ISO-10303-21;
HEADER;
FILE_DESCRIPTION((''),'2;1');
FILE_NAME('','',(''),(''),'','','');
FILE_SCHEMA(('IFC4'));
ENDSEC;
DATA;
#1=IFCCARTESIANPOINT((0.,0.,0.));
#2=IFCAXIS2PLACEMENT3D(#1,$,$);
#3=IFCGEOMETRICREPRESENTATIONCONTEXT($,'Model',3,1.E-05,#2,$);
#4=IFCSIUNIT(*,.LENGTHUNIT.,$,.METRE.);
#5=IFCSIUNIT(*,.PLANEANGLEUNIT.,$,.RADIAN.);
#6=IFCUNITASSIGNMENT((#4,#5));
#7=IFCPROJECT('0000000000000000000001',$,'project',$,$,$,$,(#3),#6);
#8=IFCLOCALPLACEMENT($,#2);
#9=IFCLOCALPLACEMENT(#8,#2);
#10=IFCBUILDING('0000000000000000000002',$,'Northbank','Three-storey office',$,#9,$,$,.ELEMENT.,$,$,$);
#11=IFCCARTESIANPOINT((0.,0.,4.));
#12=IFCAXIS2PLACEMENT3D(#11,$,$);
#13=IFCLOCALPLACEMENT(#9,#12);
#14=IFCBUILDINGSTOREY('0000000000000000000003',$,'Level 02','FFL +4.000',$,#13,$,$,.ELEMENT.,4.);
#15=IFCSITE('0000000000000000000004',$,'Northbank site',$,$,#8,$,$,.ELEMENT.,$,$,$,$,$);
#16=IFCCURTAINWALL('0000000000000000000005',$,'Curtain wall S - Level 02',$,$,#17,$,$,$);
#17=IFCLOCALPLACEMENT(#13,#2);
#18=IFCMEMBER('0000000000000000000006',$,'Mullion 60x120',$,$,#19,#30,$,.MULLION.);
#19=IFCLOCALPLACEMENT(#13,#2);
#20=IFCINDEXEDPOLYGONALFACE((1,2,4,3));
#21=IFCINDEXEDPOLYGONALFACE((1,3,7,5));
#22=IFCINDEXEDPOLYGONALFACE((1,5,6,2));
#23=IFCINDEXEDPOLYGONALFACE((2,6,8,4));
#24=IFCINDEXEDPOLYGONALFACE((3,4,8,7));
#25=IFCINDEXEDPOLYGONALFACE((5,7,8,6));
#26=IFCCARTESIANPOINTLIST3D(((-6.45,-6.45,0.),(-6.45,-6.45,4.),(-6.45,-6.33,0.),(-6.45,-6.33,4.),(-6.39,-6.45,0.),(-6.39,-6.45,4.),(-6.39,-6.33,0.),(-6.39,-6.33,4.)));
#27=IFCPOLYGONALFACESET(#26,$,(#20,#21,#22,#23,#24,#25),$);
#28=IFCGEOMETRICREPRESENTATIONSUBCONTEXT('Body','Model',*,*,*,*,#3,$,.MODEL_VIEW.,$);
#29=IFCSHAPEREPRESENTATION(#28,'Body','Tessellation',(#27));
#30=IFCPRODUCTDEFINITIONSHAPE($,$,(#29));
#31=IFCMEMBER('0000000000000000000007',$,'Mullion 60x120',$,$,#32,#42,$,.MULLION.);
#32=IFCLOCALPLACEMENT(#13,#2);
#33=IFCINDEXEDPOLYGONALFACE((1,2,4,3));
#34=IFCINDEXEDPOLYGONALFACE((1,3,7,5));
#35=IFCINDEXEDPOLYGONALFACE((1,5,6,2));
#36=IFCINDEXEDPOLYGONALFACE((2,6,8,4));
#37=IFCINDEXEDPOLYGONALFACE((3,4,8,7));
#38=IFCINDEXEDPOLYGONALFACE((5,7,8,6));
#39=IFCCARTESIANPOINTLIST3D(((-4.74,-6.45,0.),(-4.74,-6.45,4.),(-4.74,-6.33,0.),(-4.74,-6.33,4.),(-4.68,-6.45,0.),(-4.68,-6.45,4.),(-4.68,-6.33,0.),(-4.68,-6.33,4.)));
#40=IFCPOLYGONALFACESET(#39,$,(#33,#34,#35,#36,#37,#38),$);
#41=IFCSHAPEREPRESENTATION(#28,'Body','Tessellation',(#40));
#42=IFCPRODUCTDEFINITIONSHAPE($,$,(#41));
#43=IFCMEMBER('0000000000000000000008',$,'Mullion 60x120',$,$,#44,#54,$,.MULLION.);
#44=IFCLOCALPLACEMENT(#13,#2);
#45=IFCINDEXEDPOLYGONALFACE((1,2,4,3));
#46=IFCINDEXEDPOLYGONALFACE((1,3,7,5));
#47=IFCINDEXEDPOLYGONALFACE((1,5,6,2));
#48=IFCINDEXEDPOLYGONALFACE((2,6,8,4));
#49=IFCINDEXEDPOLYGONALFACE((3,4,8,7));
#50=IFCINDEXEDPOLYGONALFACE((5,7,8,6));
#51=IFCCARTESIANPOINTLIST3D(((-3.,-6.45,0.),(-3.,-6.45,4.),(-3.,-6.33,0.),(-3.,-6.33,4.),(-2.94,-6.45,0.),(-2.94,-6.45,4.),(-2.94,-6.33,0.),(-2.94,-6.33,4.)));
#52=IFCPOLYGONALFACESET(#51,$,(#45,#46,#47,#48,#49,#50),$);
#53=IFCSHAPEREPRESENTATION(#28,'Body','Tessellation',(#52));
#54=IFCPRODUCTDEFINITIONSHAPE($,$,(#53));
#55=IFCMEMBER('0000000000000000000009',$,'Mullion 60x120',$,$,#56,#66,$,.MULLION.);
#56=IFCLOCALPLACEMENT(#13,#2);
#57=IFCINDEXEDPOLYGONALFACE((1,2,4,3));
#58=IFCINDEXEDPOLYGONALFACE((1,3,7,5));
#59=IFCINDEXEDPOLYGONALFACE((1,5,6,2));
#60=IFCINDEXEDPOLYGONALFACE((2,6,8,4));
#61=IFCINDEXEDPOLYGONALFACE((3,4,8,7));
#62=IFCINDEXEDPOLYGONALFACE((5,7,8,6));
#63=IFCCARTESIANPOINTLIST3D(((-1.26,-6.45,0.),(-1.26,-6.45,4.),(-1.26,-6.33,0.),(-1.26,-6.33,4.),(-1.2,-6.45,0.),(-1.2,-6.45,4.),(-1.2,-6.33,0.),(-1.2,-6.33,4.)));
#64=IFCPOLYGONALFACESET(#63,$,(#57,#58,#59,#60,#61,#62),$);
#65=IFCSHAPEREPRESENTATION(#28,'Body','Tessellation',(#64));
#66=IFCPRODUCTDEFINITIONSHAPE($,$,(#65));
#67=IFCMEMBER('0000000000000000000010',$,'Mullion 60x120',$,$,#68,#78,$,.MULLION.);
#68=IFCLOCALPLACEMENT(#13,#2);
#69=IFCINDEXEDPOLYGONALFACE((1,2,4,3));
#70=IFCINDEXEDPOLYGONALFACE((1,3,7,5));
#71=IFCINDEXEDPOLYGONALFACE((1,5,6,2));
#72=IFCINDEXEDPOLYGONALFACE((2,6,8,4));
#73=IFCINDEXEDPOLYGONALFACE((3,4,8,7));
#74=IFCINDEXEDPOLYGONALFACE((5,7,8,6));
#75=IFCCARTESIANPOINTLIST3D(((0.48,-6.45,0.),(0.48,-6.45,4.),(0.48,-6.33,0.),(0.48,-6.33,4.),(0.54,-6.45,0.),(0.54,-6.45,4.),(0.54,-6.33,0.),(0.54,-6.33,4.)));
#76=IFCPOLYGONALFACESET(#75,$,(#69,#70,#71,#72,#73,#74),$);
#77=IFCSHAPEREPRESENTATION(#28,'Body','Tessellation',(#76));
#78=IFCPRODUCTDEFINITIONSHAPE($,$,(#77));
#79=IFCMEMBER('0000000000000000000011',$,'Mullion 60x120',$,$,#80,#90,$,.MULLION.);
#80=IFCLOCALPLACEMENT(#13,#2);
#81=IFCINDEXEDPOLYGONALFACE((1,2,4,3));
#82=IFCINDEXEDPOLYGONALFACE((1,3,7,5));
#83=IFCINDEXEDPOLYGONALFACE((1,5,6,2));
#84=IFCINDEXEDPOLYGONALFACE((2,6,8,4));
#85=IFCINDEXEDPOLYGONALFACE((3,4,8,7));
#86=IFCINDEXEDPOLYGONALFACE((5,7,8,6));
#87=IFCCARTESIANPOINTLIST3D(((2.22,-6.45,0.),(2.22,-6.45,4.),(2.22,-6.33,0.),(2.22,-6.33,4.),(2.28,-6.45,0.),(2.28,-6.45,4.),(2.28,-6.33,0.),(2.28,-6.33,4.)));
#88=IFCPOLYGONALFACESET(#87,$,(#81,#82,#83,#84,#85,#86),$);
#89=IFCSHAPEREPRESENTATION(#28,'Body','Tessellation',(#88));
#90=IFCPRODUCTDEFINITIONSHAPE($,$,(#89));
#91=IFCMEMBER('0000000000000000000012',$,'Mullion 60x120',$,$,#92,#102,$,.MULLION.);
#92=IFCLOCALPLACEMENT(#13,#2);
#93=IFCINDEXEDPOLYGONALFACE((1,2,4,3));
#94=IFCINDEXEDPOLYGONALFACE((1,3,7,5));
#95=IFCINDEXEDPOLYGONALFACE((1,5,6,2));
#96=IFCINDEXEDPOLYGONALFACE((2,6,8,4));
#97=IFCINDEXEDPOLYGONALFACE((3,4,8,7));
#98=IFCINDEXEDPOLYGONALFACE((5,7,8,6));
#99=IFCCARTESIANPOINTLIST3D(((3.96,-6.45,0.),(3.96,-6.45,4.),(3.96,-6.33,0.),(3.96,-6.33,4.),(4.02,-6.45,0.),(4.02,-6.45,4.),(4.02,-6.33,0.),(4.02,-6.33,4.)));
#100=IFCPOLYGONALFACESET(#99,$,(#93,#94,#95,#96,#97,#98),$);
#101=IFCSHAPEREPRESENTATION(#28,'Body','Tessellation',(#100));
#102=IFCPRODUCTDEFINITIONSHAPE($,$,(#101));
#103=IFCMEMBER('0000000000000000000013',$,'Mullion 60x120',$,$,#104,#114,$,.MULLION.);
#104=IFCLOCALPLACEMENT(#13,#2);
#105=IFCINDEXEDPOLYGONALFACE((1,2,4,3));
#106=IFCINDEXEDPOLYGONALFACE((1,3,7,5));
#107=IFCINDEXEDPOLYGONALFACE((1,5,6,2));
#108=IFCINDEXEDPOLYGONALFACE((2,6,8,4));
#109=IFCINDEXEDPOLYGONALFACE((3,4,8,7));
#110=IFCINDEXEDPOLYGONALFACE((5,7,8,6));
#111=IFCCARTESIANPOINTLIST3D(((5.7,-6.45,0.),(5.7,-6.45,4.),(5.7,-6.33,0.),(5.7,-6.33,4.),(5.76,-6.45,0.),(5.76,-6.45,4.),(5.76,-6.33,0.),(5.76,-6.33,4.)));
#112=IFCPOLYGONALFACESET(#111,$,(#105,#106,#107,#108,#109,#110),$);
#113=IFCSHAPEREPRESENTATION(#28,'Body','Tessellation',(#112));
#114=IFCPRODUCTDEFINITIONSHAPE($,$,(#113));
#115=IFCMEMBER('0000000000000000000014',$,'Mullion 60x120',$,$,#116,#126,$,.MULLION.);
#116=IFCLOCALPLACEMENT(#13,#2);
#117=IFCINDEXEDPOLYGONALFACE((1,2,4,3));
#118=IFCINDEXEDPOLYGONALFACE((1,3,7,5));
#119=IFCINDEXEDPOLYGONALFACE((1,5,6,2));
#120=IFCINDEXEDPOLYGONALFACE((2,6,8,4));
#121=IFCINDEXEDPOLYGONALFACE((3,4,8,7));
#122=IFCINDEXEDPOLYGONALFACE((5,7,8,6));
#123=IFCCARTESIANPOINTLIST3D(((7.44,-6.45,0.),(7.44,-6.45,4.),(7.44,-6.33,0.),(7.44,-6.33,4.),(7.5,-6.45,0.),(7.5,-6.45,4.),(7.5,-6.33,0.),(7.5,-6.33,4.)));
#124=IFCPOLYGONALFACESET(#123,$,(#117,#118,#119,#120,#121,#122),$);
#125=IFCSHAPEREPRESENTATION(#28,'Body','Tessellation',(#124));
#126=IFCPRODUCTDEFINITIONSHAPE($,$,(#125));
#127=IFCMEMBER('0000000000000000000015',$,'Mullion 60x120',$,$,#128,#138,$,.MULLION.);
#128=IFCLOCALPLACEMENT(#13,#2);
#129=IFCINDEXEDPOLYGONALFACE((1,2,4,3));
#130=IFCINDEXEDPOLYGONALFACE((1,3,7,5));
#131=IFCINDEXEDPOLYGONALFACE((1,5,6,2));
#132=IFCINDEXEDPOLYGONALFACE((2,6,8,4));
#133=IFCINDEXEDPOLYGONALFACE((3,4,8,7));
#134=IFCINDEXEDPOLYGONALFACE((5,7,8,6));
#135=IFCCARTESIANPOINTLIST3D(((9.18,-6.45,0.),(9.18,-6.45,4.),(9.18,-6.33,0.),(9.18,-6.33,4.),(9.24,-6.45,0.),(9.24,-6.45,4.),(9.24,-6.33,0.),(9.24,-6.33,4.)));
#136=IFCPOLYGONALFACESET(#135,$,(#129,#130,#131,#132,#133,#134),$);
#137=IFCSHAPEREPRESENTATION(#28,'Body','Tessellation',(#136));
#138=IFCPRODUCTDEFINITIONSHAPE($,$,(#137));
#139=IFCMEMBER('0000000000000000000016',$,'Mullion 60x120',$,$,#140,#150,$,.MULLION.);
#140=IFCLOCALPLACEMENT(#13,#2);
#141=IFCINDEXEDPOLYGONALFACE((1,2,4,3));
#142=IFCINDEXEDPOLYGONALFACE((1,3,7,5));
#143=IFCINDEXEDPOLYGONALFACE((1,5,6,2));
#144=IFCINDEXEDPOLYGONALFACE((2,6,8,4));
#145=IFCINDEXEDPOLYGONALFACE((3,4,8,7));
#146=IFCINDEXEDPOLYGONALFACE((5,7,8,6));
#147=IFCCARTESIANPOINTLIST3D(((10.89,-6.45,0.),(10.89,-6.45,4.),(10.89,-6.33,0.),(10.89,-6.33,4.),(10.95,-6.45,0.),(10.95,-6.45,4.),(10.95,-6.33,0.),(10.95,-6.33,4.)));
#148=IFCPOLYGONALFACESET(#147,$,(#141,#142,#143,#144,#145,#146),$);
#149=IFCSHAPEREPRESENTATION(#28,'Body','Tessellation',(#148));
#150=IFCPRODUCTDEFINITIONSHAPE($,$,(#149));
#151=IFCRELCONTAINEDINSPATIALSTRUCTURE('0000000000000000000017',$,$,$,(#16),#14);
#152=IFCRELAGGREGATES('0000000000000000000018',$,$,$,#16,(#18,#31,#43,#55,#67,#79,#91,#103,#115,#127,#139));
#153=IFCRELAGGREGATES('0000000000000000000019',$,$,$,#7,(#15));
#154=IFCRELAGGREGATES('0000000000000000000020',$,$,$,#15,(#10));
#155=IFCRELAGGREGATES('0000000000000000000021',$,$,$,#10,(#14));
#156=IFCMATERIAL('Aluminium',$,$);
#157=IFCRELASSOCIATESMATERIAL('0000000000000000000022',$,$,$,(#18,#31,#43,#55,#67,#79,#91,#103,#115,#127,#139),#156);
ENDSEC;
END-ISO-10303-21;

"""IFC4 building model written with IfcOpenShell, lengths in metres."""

from ifc_helpers import new_model, si_unit, frame, origin, place, context, subcontext, project, spatial, rectangle, extrude, material, element, aggregate, save


model = new_model("IFC4")

# Units and contexts
model_context = context("Model", 3, precision=1e-05, world=origin())
body_context = subcontext(model_context, "Body", "Model", "MODEL_VIEW")
ifc_project = project(units=[si_unit("LENGTHUNIT", "METRE"), si_unit("PLANEANGLEUNIT", "RADIAN")], contexts=[model_context])

# Site, building, storey
site_placement = place(None, origin())
site = spatial("IfcSite", under=ifc_project, at=site_placement, Name="Northbank site", CompositionType="ELEMENT")
building_placement = place(site_placement, origin())
building = spatial("IfcBuilding", under=site, at=building_placement, Name="Northbank", Description="Three-storey office", CompositionType="ELEMENT")
storey_placement = place(building_placement, frame((0.0, 0.0, 4.0)))
storey = spatial("IfcBuildingStorey", under=building, at=storey_placement, Name="Level 02", Description="FFL +4.000", CompositionType="ELEMENT", Elevation=4.0)

# Curtain wall, members
curtain_wall_placement = place(storey_placement, frame((0.0, 0.0, -4.0)))
curtain_wall = element("IfcCurtainWall", 1, at=curtain_wall_placement, inside=storey, Name="Curtain wall S - Level 02")
ifc_material = material(Name="Aluminium")
member_1_placement = place(storey_placement, frame((0.0, 0.0, -4.0)))
member_1 = element("IfcMember", 2, at=member_1_placement, material=ifc_material, Name="Mullion 60x120", PredefinedType="MULLION", context=body_context, shape_type="SweptSolid", body=[
    extrude(rectangle(XDim=0.06, YDim=0.12), frame((-6.42, -6.39, 4.0)), (0.0, 0.0, 1.0), 4.0),
])
member_2_placement = place(storey_placement, frame((0.0, 0.0, -4.0)))
member_2 = element("IfcMember", 3, at=member_2_placement, material=ifc_material, Name="Mullion 60x120", PredefinedType="MULLION", context=body_context, shape_type="SweptSolid", body=[
    extrude(rectangle(XDim=0.06, YDim=0.12), frame((-4.71, -6.39, 4.0)), (0.0, 0.0, 1.0), 4.0),
])
member_3_placement = place(storey_placement, frame((0.0, 0.0, -4.0)))
member_3 = element("IfcMember", 4, at=member_3_placement, material=ifc_material, Name="Mullion 60x120", PredefinedType="MULLION", context=body_context, shape_type="SweptSolid", body=[
    extrude(rectangle(XDim=0.06, YDim=0.12), frame((-2.97, -6.39, 4.0)), (0.0, 0.0, 1.0), 4.0),
])
member_4_placement = place(storey_placement, frame((0.0, 0.0, -4.0)))
member_4 = element("IfcMember", 5, at=member_4_placement, material=ifc_material, Name="Mullion 60x120", PredefinedType="MULLION", context=body_context, shape_type="SweptSolid", body=[
    extrude(rectangle(XDim=0.06, YDim=0.12), frame((-1.23, -6.39, 4.0)), (0.0, 0.0, 1.0), 4.0),
])
member_5_placement = place(storey_placement, frame((0.0, 0.0, -4.0)))
member_5 = element("IfcMember", 6, at=member_5_placement, material=ifc_material, Name="Mullion 60x120", PredefinedType="MULLION", context=body_context, shape_type="SweptSolid", body=[
    extrude(rectangle(XDim=0.06, YDim=0.12), frame((0.51, -6.39, 4.0)), (0.0, 0.0, 1.0), 4.0),
])
member_6_placement = place(storey_placement, frame((0.0, 0.0, -4.0)))
member_6 = element("IfcMember", 7, at=member_6_placement, material=ifc_material, Name="Mullion 60x120", PredefinedType="MULLION", context=body_context, shape_type="SweptSolid", body=[
    extrude(rectangle(XDim=0.06, YDim=0.12), frame((2.25, -6.39, 4.0)), (0.0, 0.0, 1.0), 4.0),
])
member_7_placement = place(storey_placement, frame((0.0, 0.0, -4.0)))
member_7 = element("IfcMember", 8, at=member_7_placement, material=ifc_material, Name="Mullion 60x120", PredefinedType="MULLION", context=body_context, shape_type="SweptSolid", body=[
    extrude(rectangle(XDim=0.06, YDim=0.12), frame((3.99, -6.39, 4.0)), (0.0, 0.0, 1.0), 4.0),
])
member_8_placement = place(storey_placement, frame((0.0, 0.0, -4.0)))
member_8 = element("IfcMember", 9, at=member_8_placement, material=ifc_material, Name="Mullion 60x120", PredefinedType="MULLION", context=body_context, shape_type="SweptSolid", body=[
    extrude(rectangle(XDim=0.06, YDim=0.12), frame((5.73, -6.39, 4.0)), (0.0, 0.0, 1.0), 4.0),
])
member_9_placement = place(storey_placement, frame((0.0, 0.0, -4.0)))
member_9 = element("IfcMember", 10, at=member_9_placement, material=ifc_material, Name="Mullion 60x120", PredefinedType="MULLION", context=body_context, shape_type="SweptSolid", body=[
    extrude(rectangle(XDim=0.06, YDim=0.12), frame((7.47, -6.39, 4.0)), (0.0, 0.0, 1.0), 4.0),
])
member_10_placement = place(storey_placement, frame((0.0, 0.0, -4.0)))
member_10 = element("IfcMember", 11, at=member_10_placement, material=ifc_material, Name="Mullion 60x120", PredefinedType="MULLION", context=body_context, shape_type="SweptSolid", body=[
    extrude(rectangle(XDim=0.06, YDim=0.12), frame((9.21, -6.39, 4.0)), (0.0, 0.0, 1.0), 4.0),
])
member_11_placement = place(storey_placement, frame((0.0, 0.0, -4.0)))
member_11 = element("IfcMember", 12, at=member_11_placement, material=ifc_material, Name="Mullion 60x120", PredefinedType="MULLION", context=body_context, shape_type="SweptSolid", body=[
    extrude(rectangle(XDim=0.06, YDim=0.12), frame((10.92, -6.39, 4.0)), (0.0, 0.0, 1.0), 4.0),
])
aggregate(curtain_wall, [member_1, member_2, member_3, member_4, member_5, member_6, member_7, member_8, member_9, member_10, member_11])

save(model, "model.ifc")
